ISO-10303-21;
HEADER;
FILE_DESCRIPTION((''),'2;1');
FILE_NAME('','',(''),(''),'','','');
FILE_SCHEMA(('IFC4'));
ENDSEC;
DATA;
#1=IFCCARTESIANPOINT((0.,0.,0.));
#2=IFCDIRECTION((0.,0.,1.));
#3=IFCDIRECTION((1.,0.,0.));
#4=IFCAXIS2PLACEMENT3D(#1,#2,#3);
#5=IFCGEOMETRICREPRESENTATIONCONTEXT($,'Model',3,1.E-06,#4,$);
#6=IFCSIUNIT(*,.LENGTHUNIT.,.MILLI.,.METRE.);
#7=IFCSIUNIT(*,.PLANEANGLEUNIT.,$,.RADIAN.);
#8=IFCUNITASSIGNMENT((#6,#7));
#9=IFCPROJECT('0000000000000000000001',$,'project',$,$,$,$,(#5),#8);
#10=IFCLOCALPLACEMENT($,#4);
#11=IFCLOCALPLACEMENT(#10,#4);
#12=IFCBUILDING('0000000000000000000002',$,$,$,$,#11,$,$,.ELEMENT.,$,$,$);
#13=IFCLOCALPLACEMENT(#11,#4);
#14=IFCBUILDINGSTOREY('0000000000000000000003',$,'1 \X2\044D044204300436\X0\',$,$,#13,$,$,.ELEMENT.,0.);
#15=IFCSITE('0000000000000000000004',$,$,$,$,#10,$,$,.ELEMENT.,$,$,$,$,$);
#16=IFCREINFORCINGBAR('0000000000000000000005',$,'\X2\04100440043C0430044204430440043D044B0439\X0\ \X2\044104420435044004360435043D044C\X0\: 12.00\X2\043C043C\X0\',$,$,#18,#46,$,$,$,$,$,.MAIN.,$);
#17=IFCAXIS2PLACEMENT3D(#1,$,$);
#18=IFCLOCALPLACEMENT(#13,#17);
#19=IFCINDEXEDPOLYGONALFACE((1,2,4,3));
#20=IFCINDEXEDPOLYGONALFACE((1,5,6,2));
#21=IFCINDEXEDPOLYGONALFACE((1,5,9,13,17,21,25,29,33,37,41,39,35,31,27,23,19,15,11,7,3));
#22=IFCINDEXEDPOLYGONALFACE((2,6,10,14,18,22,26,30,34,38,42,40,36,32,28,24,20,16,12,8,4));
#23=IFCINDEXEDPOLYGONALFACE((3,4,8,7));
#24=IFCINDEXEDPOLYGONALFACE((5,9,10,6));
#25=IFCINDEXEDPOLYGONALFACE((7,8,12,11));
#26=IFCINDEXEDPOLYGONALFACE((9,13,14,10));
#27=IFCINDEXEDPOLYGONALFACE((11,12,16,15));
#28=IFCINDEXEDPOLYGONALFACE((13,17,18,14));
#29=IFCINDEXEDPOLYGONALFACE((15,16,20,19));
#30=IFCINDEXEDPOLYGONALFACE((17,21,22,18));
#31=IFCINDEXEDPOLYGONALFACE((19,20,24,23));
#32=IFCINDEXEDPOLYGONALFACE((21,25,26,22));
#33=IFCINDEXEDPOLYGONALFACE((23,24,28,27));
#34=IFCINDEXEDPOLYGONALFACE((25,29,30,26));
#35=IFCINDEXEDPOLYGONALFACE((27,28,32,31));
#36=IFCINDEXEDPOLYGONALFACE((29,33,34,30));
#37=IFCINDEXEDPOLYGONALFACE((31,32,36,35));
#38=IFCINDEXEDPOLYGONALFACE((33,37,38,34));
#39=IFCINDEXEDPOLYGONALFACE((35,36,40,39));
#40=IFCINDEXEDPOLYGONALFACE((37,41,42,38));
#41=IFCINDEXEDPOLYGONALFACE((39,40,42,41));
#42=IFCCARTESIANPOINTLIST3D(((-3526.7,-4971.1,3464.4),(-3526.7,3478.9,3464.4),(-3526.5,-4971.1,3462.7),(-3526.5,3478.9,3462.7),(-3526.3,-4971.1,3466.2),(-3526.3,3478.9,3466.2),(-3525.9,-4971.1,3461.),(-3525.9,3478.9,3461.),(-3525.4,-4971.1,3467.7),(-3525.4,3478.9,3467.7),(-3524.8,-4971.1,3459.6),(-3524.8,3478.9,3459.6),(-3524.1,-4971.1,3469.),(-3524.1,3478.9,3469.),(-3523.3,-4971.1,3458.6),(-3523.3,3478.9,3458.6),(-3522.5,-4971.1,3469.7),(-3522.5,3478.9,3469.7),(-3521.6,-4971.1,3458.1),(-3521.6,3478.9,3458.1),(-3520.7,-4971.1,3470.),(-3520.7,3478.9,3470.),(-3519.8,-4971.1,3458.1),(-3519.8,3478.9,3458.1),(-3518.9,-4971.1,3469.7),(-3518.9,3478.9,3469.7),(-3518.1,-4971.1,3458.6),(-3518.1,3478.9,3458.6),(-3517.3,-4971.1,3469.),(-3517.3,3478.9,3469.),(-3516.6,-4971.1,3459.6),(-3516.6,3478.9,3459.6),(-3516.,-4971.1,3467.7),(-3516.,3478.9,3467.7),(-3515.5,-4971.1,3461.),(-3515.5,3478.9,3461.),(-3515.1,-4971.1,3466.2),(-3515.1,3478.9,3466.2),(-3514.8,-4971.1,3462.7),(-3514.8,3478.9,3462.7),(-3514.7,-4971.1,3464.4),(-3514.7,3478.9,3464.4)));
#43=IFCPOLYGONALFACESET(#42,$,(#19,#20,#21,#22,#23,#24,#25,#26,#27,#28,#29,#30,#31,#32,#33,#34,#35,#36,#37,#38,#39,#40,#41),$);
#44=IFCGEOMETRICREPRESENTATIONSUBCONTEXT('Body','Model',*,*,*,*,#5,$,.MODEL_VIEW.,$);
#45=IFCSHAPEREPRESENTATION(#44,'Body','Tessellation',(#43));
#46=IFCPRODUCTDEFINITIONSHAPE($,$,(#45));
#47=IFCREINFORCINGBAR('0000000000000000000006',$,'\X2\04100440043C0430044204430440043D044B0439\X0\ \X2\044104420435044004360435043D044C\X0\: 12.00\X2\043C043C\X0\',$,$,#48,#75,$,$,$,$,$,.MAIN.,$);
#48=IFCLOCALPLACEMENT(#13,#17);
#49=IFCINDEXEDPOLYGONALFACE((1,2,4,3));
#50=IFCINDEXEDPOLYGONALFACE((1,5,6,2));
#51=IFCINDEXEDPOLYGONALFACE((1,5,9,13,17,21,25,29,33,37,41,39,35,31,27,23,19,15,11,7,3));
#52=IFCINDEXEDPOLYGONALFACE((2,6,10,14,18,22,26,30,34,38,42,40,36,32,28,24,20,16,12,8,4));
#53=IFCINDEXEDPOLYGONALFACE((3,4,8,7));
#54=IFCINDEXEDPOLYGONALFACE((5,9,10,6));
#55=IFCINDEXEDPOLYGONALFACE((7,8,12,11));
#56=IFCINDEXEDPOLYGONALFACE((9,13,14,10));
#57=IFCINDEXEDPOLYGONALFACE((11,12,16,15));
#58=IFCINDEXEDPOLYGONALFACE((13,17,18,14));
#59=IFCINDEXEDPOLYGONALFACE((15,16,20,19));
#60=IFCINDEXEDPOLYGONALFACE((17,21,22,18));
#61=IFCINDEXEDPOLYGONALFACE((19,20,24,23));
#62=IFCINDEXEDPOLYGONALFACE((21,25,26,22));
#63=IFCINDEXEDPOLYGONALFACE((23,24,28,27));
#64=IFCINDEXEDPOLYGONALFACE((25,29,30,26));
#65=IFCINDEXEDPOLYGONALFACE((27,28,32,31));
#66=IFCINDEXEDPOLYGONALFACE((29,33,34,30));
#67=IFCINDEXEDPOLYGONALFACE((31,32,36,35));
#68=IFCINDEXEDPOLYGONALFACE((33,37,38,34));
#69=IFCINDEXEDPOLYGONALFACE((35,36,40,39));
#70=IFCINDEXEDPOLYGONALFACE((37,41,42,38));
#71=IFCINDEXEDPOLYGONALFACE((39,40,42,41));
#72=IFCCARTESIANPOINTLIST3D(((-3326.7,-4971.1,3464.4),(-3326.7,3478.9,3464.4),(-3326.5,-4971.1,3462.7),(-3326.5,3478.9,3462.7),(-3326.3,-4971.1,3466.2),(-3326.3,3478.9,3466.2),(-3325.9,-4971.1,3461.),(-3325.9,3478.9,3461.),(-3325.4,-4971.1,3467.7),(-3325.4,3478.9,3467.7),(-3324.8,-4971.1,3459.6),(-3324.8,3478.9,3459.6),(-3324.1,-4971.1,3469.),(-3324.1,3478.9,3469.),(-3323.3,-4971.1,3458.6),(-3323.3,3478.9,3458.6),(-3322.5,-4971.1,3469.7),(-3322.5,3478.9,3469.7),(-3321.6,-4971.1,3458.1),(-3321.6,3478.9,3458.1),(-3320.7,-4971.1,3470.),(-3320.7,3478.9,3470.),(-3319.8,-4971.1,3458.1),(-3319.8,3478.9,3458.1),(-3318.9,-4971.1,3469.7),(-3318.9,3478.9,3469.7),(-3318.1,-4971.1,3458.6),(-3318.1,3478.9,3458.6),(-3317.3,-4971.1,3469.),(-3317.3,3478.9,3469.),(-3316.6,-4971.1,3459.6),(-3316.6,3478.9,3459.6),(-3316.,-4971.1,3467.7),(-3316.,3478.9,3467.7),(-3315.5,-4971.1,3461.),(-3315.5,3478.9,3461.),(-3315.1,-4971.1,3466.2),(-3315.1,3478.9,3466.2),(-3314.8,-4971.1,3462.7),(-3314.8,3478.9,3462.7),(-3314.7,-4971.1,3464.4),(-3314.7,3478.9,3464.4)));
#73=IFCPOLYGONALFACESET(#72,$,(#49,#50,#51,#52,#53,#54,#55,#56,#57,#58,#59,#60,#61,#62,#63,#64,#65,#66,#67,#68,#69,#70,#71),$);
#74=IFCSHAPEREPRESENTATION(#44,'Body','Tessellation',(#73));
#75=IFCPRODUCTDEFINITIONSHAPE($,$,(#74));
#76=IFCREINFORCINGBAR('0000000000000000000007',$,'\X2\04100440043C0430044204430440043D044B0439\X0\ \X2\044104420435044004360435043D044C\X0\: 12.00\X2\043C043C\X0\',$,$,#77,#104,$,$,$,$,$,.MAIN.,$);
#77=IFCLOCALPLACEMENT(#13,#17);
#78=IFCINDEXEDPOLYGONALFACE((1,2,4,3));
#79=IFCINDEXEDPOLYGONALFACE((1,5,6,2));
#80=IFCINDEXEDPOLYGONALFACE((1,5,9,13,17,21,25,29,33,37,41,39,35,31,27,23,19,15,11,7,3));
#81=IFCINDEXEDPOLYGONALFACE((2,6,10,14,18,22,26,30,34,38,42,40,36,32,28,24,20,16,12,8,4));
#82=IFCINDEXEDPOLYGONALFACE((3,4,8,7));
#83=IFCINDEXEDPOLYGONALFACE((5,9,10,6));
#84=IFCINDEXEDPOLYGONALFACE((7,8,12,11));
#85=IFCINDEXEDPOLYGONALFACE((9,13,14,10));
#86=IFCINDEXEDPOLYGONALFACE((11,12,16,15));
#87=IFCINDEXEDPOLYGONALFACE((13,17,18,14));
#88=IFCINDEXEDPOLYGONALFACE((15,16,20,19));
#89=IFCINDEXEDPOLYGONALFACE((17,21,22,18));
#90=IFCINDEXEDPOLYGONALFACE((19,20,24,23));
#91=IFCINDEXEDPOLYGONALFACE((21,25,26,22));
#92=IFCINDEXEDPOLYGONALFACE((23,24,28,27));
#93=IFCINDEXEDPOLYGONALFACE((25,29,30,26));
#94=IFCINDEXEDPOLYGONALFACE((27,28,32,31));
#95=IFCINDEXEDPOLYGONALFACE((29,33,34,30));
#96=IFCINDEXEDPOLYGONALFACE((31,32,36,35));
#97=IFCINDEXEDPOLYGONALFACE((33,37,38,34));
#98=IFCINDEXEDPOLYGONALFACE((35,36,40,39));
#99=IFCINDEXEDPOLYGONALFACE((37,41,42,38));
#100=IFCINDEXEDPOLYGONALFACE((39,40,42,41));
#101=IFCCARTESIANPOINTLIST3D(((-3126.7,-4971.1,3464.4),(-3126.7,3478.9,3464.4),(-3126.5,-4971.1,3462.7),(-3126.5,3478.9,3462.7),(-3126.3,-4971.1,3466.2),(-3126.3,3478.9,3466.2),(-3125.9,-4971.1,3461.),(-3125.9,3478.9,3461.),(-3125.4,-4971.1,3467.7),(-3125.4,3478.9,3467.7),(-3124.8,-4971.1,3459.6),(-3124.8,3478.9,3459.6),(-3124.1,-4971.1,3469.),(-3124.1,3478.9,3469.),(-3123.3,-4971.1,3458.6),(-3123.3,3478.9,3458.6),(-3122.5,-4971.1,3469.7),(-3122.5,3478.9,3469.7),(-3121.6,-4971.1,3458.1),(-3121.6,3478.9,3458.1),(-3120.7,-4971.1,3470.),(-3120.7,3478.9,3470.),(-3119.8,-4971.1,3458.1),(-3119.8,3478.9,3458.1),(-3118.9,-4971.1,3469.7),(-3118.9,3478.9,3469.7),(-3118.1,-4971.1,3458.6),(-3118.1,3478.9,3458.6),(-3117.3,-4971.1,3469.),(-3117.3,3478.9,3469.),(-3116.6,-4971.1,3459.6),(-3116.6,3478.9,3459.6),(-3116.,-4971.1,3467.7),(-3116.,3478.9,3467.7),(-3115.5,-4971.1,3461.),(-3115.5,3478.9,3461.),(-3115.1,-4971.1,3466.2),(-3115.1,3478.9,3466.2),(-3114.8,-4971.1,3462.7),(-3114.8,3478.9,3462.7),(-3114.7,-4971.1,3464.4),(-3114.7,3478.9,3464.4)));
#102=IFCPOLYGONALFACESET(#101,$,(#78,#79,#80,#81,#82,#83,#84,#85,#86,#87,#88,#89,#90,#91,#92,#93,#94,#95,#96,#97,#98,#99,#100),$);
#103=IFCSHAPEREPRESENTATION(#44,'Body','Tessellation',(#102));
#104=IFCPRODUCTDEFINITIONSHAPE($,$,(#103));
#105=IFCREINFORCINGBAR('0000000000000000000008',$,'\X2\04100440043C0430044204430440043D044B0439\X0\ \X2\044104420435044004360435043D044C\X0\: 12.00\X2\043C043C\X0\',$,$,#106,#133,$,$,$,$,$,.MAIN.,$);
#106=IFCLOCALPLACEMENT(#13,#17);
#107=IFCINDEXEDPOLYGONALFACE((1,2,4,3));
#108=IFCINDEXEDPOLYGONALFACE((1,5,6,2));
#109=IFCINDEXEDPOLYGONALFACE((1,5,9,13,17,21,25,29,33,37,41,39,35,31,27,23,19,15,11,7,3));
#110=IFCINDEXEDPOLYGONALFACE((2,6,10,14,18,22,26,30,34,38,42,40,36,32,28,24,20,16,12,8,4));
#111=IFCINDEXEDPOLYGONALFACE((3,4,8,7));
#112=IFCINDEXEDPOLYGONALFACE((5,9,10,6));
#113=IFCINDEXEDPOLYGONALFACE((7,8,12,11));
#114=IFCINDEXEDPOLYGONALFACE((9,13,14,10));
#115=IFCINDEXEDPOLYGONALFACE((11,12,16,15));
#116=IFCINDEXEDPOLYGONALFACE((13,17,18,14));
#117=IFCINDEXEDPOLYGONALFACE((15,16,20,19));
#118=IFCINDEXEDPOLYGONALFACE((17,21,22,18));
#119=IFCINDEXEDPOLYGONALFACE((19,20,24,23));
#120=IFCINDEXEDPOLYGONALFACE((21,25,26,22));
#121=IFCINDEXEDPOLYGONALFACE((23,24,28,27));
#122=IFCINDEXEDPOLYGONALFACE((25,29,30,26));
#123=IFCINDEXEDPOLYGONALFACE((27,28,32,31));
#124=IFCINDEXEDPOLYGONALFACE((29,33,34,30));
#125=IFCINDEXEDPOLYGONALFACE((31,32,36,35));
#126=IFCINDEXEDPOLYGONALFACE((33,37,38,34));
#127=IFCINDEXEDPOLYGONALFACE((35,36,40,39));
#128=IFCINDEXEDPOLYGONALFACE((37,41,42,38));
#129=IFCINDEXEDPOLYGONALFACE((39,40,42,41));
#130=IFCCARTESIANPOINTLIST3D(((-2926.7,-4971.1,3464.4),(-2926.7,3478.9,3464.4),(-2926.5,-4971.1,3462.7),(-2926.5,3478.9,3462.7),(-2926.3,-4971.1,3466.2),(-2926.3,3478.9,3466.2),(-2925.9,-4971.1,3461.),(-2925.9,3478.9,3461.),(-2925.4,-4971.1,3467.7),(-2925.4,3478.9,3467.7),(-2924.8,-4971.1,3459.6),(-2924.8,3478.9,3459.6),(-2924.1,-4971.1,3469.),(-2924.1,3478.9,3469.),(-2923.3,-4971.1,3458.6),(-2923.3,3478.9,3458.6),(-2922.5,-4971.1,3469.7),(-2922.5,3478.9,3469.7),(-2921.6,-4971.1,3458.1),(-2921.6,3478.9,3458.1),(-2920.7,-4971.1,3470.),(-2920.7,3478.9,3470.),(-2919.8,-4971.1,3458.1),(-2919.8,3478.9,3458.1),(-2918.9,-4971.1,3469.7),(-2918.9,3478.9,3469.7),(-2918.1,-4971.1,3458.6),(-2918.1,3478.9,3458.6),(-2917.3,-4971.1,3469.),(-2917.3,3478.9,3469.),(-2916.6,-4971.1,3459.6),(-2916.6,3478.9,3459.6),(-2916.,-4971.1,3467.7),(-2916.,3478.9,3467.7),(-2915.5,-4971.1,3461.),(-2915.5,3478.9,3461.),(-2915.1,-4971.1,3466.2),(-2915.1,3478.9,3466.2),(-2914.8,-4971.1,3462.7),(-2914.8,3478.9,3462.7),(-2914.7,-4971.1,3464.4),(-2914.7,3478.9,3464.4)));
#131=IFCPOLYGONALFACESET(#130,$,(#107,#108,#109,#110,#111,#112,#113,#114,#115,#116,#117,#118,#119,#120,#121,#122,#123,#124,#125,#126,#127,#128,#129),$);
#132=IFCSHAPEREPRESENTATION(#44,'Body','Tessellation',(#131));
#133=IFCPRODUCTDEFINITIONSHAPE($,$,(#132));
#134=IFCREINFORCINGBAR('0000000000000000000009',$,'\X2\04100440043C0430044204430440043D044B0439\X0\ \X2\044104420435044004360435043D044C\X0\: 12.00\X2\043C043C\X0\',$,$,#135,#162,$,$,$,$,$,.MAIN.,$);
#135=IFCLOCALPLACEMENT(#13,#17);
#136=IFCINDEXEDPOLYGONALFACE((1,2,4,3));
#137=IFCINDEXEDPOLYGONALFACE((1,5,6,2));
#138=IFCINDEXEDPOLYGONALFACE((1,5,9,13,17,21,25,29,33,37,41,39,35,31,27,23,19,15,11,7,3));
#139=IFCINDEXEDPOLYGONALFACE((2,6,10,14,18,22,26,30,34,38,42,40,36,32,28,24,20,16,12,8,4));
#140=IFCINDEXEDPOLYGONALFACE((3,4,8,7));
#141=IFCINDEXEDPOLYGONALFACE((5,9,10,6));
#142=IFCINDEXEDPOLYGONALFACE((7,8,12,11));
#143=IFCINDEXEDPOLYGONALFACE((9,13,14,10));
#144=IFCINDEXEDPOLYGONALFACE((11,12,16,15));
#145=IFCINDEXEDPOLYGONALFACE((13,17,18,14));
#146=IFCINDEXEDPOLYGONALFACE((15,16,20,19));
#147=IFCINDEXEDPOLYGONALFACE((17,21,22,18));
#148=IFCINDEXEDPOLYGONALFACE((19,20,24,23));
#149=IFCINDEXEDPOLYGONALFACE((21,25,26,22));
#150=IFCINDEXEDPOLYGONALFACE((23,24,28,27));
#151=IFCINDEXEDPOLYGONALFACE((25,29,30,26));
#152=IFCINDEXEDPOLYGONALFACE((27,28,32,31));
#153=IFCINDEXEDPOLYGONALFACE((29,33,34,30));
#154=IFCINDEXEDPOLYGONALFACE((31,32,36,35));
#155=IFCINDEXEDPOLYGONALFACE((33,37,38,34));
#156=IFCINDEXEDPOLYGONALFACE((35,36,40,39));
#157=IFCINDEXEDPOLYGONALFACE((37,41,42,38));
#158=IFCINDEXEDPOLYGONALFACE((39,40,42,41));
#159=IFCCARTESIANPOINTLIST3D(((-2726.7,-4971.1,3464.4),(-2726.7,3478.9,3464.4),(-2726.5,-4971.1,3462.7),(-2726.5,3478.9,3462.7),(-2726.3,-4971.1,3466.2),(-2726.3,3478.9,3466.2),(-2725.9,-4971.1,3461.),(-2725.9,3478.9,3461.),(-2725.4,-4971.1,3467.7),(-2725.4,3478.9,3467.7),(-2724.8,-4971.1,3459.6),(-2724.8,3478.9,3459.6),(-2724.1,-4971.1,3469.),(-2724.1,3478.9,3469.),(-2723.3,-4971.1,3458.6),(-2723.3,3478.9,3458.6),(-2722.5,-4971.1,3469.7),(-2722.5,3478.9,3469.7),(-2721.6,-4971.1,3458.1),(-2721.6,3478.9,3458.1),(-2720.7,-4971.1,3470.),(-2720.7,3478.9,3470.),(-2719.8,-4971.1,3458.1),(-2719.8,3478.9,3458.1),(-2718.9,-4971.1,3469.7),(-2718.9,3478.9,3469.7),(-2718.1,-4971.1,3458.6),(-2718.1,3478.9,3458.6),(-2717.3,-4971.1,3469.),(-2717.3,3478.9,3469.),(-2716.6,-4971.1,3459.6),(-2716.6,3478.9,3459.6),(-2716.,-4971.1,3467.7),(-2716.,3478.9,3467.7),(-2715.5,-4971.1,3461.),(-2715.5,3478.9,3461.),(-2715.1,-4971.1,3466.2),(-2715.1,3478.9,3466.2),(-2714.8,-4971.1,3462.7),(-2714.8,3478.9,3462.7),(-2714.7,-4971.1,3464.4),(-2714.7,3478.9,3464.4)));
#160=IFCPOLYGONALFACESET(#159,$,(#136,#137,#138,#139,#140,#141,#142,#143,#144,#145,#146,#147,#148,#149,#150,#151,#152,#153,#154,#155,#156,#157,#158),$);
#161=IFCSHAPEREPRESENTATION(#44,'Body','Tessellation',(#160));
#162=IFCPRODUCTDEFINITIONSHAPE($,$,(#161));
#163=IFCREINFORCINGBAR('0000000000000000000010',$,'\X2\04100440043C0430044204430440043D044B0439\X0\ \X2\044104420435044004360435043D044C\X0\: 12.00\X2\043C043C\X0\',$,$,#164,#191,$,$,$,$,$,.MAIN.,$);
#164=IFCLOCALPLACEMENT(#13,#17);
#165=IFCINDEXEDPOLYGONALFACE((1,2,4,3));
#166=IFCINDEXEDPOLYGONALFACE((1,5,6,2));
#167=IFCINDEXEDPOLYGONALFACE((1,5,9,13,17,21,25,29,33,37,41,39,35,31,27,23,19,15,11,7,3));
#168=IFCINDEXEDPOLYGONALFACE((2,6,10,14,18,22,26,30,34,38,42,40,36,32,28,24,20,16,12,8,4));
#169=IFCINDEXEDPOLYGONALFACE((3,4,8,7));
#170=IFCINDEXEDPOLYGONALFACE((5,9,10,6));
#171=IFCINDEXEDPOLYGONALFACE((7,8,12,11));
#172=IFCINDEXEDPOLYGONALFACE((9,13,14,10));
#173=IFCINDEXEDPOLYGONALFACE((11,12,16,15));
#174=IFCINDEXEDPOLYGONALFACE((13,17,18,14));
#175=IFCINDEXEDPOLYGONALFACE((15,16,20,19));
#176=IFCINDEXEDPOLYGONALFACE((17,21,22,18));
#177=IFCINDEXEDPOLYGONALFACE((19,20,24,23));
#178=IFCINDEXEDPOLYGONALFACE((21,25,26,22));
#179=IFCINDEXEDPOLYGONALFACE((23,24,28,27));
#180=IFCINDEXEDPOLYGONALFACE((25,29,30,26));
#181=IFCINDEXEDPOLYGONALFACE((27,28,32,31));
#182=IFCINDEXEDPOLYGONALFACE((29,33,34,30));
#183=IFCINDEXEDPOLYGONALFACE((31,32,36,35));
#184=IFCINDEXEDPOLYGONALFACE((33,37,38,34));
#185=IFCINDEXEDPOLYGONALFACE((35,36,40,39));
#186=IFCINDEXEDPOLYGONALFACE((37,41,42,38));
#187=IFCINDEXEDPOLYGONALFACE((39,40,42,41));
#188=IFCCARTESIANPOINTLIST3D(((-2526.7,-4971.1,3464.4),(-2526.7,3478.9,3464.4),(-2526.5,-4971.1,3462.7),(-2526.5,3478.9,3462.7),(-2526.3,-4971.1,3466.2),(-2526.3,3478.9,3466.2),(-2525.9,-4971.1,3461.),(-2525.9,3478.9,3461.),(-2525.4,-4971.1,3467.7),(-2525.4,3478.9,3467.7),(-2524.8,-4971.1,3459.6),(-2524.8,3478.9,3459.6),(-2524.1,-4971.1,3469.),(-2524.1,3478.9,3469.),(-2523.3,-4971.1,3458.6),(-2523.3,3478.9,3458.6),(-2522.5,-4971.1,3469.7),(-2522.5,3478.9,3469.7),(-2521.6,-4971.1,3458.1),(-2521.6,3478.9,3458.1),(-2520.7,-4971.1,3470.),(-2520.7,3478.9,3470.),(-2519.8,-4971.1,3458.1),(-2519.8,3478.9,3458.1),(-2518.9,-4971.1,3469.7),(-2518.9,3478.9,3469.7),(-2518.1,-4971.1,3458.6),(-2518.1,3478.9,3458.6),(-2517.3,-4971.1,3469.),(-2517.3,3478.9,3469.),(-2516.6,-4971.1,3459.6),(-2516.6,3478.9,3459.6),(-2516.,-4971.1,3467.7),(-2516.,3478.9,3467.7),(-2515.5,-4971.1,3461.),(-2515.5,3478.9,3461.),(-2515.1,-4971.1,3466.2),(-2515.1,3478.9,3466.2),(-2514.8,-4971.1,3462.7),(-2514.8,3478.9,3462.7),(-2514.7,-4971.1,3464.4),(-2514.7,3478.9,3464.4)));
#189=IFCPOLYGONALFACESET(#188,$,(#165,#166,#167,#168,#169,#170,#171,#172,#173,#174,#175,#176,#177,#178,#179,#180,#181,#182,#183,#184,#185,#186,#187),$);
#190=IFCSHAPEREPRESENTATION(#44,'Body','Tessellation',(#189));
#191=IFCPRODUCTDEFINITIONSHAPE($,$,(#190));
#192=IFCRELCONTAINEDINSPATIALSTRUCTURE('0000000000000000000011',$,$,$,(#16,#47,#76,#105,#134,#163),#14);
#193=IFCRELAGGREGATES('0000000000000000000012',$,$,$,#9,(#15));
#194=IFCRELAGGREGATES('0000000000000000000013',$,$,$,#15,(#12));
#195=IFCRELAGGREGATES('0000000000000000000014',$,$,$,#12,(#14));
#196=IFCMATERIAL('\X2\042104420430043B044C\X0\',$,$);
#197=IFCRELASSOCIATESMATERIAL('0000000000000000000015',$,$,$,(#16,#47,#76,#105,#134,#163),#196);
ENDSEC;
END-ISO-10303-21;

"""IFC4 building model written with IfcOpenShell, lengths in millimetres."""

from ifc_helpers import new_model, entity, si_unit, origin_with_axes, place, context, subcontext, project, spatial, source, transform, mapped, material, element, save


model = new_model("IFC4")

# Units and contexts
model_context = context("Model", 3, precision=1e-06, world=origin_with_axes())
body_context = subcontext(model_context, "Body", "Model", "MODEL_VIEW")
ifc_project = project(units=[si_unit("LENGTHUNIT", "METRE", prefix="MILLI"), si_unit("PLANEANGLEUNIT", "RADIAN")], contexts=[model_context])

# Site, building, storey
site_placement = place(None, origin_with_axes())
site = spatial("IfcSite", under=ifc_project, at=site_placement, CompositionType="ELEMENT")
building_placement = place(site_placement, origin_with_axes())
building = spatial("IfcBuilding", under=site, at=building_placement, CompositionType="ELEMENT")
storey_placement = place(building_placement, origin_with_axes())
storey = spatial("IfcBuildingStorey", under=building, at=storey_placement, Name="1 этаж", CompositionType="ELEMENT", Elevation=0.0)

# Reinforcing bars
ifc_material = material(Name="Сталь")
shared_shape = source(origin_with_axes(), body_context, "Body", "AdvancedSweptSolid", [
    entity("IfcSweptDiskSolid", entity("IfcIndexedPolyCurve", entity("IfcCartesianPointList3D", [[0.0, 0.0, 0.0], [8450.0, 0.0, 0.0]]), [entity("IfcLineIndex", [1, 2])]), 6.0),
])
reinforcing_bar_1_placement = place(storey_placement, origin_with_axes())
element("IfcReinforcingBar", 1, at=reinforcing_bar_1_placement, inside=storey, material=ifc_material, Name="Арматурный стержень: 12.00мм", PredefinedType="MAIN", context=body_context, shape_type="MappedRepresentation", body=[
    mapped(shared_shape, transform((-3520.7, -4971.1, 3464.0), x_axis=(0.0, 1.0, 0.0), y_axis=(-1.0, 0.0, 0.0), z_axis=(0.0, 0.0, 1.0), scale=1.0)),
])
reinforcing_bar_2_placement = place(storey_placement, origin_with_axes())
element("IfcReinforcingBar", 2, at=reinforcing_bar_2_placement, inside=storey, material=ifc_material, Name="Арматурный стержень: 12.00мм", PredefinedType="MAIN", context=body_context, shape_type="MappedRepresentation", body=[
    mapped(shared_shape, transform((-3320.7, -4971.1, 3464.0), x_axis=(0.0, 1.0, 0.0), y_axis=(-1.0, 0.0, 0.0), z_axis=(0.0, 0.0, 1.0), scale=1.0)),
])
reinforcing_bar_3_placement = place(storey_placement, origin_with_axes())
element("IfcReinforcingBar", 3, at=reinforcing_bar_3_placement, inside=storey, material=ifc_material, Name="Арматурный стержень: 12.00мм", PredefinedType="MAIN", context=body_context, shape_type="MappedRepresentation", body=[
    mapped(shared_shape, transform((-3120.7, -4971.1, 3464.0), x_axis=(0.0, 1.0, 0.0), y_axis=(-1.0, 0.0, 0.0), z_axis=(0.0, 0.0, 1.0), scale=1.0)),
])
reinforcing_bar_4_placement = place(storey_placement, origin_with_axes())
element("IfcReinforcingBar", 4, at=reinforcing_bar_4_placement, inside=storey, material=ifc_material, Name="Арматурный стержень: 12.00мм", PredefinedType="MAIN", context=body_context, shape_type="MappedRepresentation", body=[
    mapped(shared_shape, transform((-2920.7, -4971.1, 3464.0), x_axis=(0.0, 1.0, 0.0), y_axis=(-1.0, 0.0, 0.0), z_axis=(0.0, 0.0, 1.0), scale=1.0)),
])
reinforcing_bar_5_placement = place(storey_placement, origin_with_axes())
element("IfcReinforcingBar", 5, at=reinforcing_bar_5_placement, inside=storey, material=ifc_material, Name="Арматурный стержень: 12.00мм", PredefinedType="MAIN", context=body_context, shape_type="MappedRepresentation", body=[
    mapped(shared_shape, transform((-2720.7, -4971.1, 3464.0), x_axis=(0.0, 1.0, 0.0), y_axis=(-1.0, 0.0, 0.0), z_axis=(0.0, 0.0, 1.0), scale=1.0)),
])
reinforcing_bar_6_placement = place(storey_placement, origin_with_axes())
element("IfcReinforcingBar", 6, at=reinforcing_bar_6_placement, inside=storey, material=ifc_material, Name="Арматурный стержень: 12.00мм", PredefinedType="MAIN", context=body_context, shape_type="MappedRepresentation", body=[
    mapped(shared_shape, transform((-2520.7, -4971.1, 3464.0), x_axis=(0.0, 1.0, 0.0), y_axis=(-1.0, 0.0, 0.0), z_axis=(0.0, 0.0, 1.0), scale=1.0)),
])

save(model, "model.ifc")
